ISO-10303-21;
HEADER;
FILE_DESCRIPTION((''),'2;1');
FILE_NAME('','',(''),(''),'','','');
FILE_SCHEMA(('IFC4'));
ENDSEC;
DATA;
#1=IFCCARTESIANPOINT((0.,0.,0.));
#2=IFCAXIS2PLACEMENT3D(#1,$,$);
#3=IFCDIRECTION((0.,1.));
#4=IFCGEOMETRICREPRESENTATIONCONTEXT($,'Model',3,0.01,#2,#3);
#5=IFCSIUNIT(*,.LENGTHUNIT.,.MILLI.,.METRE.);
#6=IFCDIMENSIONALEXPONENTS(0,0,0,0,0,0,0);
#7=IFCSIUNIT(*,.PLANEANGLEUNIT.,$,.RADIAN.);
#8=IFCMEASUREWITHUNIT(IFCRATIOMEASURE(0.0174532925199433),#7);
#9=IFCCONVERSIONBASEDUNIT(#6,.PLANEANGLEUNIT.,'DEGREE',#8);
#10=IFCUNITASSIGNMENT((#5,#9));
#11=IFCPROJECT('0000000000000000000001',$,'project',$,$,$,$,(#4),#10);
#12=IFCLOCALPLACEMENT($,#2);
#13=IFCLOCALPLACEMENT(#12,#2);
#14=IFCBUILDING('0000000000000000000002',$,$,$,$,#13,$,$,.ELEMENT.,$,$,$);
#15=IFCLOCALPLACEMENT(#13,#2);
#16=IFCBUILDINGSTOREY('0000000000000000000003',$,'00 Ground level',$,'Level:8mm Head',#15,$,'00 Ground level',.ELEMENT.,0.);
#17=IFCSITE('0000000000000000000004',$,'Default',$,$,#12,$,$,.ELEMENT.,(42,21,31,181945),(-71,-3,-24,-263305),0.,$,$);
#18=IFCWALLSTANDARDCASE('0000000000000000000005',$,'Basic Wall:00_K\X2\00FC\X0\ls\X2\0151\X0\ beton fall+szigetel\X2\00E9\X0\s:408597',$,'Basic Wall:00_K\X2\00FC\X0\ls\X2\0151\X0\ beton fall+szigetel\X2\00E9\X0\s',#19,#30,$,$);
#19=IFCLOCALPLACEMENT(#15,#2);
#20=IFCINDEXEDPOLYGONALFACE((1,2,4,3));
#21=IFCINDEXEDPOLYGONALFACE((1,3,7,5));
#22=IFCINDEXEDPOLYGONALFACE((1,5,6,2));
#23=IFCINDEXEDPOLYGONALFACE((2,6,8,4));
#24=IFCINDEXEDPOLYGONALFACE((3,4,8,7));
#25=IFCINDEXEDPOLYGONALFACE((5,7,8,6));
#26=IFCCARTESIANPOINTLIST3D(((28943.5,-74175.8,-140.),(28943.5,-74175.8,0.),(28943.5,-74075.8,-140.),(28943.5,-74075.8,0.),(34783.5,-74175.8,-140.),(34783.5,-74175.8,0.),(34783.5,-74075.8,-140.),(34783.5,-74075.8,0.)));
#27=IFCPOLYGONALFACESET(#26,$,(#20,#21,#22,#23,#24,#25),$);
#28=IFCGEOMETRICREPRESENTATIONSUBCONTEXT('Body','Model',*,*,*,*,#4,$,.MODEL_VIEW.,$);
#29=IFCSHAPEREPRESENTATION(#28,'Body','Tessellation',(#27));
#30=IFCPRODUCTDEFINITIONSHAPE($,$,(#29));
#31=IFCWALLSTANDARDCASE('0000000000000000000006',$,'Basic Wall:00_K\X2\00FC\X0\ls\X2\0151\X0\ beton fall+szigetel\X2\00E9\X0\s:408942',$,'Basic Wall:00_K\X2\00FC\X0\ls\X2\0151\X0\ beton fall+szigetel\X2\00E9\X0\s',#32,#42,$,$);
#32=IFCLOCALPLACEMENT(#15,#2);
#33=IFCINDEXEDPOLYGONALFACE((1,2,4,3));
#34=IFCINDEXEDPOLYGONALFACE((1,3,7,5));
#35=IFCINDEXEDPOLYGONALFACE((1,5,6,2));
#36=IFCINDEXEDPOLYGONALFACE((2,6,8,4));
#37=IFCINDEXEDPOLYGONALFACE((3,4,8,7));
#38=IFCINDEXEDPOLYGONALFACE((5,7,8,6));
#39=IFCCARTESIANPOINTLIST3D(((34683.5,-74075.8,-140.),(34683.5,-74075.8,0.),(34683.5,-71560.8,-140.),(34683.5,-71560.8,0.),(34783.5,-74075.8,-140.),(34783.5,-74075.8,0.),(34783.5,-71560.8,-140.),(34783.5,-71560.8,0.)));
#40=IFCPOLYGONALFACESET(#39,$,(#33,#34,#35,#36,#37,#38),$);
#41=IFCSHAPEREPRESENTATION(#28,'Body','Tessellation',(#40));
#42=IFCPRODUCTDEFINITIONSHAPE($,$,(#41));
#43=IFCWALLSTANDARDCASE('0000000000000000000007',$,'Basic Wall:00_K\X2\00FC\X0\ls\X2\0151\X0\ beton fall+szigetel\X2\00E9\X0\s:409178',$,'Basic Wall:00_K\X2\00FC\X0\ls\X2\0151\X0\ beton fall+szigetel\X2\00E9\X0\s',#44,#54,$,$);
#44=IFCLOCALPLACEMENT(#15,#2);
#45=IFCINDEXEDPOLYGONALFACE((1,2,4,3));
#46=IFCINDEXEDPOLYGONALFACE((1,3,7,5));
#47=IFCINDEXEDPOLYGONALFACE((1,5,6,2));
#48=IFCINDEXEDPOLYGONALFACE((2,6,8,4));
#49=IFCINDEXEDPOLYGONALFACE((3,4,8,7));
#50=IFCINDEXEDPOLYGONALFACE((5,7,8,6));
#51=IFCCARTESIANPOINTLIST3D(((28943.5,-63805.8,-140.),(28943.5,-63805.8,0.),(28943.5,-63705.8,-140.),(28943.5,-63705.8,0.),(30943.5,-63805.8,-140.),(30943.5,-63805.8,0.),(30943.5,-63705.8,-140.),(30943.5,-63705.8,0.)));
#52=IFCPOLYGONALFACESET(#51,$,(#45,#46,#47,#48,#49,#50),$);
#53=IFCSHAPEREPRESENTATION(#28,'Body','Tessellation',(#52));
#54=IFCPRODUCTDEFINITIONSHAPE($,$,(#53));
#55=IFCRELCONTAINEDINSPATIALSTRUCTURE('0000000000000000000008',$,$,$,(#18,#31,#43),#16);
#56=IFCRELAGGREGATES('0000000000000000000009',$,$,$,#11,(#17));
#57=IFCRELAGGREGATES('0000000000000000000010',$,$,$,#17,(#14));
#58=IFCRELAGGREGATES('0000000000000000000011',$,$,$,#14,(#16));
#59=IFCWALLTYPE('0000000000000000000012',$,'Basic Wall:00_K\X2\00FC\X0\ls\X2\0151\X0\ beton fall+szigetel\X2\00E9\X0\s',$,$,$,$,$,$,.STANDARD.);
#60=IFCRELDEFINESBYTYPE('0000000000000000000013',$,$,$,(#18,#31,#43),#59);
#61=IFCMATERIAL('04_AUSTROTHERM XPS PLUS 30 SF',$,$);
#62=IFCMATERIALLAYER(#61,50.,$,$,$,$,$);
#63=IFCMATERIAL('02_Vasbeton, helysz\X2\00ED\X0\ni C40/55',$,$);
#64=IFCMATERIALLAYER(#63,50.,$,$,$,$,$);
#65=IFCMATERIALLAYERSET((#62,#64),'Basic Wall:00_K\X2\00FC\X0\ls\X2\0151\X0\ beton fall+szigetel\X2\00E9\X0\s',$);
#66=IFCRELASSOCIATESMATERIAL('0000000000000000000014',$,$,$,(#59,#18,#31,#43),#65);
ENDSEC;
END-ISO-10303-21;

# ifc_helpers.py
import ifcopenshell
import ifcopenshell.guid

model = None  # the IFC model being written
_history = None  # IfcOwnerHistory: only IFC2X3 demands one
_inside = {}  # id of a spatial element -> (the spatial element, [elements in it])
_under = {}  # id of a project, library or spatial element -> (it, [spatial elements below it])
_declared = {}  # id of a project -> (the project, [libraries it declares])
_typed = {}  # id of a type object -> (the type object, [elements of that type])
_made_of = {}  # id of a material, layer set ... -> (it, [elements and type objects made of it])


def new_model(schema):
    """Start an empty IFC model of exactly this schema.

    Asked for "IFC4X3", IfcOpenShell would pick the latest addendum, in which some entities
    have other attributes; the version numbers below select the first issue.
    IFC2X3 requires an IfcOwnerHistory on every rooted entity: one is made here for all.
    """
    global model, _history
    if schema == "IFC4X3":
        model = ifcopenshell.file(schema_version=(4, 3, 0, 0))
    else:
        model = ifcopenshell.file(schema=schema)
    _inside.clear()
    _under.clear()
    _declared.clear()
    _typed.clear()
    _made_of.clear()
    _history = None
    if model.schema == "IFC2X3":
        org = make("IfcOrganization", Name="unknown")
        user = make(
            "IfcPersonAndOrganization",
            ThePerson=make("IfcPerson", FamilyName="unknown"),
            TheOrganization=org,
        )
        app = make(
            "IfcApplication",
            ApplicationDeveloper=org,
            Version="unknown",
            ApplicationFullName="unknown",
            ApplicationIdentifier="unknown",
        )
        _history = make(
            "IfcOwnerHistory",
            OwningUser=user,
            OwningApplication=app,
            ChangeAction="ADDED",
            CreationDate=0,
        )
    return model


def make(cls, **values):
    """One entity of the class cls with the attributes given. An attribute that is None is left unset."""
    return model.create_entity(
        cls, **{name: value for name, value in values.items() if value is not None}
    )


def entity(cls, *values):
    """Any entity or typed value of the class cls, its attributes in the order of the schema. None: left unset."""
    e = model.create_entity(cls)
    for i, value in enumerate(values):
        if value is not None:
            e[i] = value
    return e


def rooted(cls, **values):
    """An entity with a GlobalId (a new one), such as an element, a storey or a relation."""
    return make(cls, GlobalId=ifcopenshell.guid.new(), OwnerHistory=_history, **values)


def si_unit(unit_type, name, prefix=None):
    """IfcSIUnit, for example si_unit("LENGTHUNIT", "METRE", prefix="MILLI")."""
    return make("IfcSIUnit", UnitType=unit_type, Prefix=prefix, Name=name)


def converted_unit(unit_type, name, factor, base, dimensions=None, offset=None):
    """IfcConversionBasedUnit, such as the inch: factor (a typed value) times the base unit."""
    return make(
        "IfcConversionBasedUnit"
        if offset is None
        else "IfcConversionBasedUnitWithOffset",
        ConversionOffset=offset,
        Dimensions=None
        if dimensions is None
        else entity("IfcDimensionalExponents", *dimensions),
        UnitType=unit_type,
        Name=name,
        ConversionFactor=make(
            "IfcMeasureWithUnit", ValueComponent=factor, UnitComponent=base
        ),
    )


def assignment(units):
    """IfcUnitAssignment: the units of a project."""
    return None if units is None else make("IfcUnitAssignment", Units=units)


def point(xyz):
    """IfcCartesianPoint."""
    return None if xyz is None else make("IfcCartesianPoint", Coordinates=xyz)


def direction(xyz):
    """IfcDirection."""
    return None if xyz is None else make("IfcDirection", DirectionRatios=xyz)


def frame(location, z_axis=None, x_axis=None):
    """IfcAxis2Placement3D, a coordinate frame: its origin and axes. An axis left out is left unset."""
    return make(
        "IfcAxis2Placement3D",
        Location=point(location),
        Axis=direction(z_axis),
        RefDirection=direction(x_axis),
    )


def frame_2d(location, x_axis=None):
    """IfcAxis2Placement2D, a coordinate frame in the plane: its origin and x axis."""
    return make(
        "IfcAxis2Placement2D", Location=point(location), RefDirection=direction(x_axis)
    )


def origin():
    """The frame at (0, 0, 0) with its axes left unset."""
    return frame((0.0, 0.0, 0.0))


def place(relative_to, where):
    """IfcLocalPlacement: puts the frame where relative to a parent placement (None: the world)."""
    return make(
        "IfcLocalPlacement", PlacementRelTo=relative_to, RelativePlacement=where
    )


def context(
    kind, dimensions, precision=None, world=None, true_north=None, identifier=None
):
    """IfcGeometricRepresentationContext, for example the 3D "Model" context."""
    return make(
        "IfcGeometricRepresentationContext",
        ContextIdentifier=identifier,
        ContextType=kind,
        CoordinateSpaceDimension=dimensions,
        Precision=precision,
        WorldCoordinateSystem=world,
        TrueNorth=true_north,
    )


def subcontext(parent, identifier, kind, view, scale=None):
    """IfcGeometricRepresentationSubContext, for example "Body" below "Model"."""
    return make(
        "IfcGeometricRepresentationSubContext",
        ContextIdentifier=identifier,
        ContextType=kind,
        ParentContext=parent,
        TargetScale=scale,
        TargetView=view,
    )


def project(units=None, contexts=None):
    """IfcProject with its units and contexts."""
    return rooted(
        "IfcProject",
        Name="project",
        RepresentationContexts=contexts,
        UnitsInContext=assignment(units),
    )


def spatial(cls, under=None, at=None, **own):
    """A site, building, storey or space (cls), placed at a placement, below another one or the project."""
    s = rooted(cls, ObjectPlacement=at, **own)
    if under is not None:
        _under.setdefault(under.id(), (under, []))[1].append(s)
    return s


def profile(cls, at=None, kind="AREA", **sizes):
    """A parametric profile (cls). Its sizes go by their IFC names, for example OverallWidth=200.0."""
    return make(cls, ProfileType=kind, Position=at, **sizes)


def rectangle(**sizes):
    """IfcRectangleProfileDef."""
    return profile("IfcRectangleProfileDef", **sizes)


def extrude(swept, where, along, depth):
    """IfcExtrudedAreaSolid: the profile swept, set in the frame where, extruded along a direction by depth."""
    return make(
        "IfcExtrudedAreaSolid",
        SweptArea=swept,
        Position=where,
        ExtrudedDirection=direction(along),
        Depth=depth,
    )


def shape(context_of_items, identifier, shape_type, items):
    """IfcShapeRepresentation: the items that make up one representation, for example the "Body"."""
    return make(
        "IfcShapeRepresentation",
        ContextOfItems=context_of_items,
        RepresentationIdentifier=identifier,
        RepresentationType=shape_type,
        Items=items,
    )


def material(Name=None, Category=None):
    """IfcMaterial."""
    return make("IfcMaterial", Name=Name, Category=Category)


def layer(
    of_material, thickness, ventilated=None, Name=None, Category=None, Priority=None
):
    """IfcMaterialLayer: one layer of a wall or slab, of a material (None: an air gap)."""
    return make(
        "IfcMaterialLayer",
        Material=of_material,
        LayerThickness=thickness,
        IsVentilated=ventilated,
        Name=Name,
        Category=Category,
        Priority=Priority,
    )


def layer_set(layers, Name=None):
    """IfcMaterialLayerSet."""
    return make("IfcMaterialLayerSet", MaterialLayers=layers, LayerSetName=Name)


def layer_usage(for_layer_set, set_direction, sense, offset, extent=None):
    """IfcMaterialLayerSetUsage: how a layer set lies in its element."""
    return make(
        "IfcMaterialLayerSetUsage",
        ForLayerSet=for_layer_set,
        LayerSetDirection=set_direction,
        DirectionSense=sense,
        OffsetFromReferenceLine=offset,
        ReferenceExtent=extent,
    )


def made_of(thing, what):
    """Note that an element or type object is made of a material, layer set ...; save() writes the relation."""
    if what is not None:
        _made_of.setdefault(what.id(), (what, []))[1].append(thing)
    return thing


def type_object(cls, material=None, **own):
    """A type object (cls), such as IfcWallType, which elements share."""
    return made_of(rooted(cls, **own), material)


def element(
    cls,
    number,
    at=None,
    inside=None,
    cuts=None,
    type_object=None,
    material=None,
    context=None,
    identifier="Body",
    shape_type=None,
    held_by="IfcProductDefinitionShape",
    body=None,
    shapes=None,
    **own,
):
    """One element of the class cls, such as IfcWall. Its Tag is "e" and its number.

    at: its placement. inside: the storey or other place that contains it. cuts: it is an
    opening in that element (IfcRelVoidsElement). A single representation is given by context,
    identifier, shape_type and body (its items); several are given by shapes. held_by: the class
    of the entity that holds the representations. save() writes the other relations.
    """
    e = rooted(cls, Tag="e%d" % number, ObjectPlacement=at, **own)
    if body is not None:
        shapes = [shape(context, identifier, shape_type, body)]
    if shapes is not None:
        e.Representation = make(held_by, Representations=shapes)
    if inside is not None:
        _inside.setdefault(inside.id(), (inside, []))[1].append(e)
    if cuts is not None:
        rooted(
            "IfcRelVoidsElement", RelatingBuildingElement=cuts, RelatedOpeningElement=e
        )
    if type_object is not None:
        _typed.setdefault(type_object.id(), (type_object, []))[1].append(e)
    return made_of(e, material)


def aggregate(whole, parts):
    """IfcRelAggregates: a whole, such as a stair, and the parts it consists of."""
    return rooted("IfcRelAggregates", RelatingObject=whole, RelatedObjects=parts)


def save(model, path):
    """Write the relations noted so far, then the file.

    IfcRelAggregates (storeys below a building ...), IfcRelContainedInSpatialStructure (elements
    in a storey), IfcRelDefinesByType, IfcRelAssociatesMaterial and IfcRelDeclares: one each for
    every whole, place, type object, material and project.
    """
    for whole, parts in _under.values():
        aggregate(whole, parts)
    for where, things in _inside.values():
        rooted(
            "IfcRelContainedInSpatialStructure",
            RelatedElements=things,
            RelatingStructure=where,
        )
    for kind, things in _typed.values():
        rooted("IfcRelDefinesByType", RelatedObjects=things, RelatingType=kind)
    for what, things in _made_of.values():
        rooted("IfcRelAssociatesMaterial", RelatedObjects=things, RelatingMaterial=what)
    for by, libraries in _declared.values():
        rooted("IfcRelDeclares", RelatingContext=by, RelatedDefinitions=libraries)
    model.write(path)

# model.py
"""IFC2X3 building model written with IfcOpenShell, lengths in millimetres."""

from ifc_helpers import new_model, entity, si_unit, converted_unit, direction, frame, frame_2d, origin, place, context, subcontext, project, spatial, rectangle, extrude, material, layer, layer_set, layer_usage, type_object, element, save


model = new_model("IFC2X3")

# Units and contexts
model_context = context("Model", 3, precision=0.01, world=origin(), true_north=direction((0.0, 1.0)))
body_context = subcontext(model_context, "Body", "Model", "MODEL_VIEW")
ifc_project = project(units=[si_unit("LENGTHUNIT", "METRE", prefix="MILLI"), converted_unit("PLANEANGLEUNIT", "DEGREE", entity("IfcRatioMeasure", 0.0174532925199433), si_unit("PLANEANGLEUNIT", "RADIAN"), dimensions=[0, 0, 0, 0, 0, 0, 0])], contexts=[model_context])

# Site, building, storey
site_placement = place(None, origin())
site = spatial("IfcSite", under=ifc_project, at=site_placement, Name="Default", CompositionType="ELEMENT", RefLatitude=(42, 21, 31, 181945), RefLongitude=(-71, -3, -24, -263305), RefElevation=0.0)
building_placement = place(site_placement, origin())
building = spatial("IfcBuilding", under=site, at=building_placement, CompositionType="ELEMENT")
storey_placement = place(building_placement, origin())
storey = spatial("IfcBuildingStorey", under=building, at=storey_placement, Name="00 Ground level", ObjectType="Level:8mm Head", LongName="00 Ground level", CompositionType="ELEMENT", Elevation=0.0)

# Walls
ifc_material_1 = material(Name="04_AUSTROTHERM XPS PLUS 30 SF")
ifc_layer_1 = layer(ifc_material_1, 50.0)
ifc_material_2 = material(Name="02_Vasbeton, helyszíni C40/55")
ifc_layer_2 = layer(ifc_material_2, 50.0)
ifc_layer_set = layer_set([ifc_layer_1, ifc_layer_2], Name="Basic Wall:00_Külső beton fall+szigetelés")
ifc_layer_usage_1 = layer_usage(ifc_layer_set, "AXIS2", "NEGATIVE", 50.0)
wall_type = type_object("IfcWallType", Name="Basic Wall:00_Külső beton fall+szigetelés", PredefinedType="STANDARD", material=ifc_layer_set)
wall_1_placement = place(storey_placement, frame((34783.5, -74125.8, -140.0), z_axis=(0.0, 0.0, 1.0), x_axis=(-1.0, 0.0, 0.0)))
element("IfcWallStandardCase", 1, at=wall_1_placement, inside=storey, type_object=wall_type, material=ifc_layer_usage_1, Name="Basic Wall:00_Külső beton fall+szigetelés:408597", ObjectType="Basic Wall:00_Külső beton fall+szigetelés", context=body_context, shape_type="SweptSolid", body=[
    extrude(rectangle(XDim=5840.0, YDim=100.0, at=frame_2d((2920.0, 0.0), x_axis=(-1.0, 0.0))), origin(), (0.0, 0.0, 1.0), 140.0),
])
ifc_layer_usage_2 = layer_usage(ifc_layer_set, "AXIS2", "NEGATIVE", 50.0)
wall_2_placement = place(storey_placement, frame((34733.5, -71560.8, -140.0), z_axis=(0.0, 0.0, 1.0), x_axis=(0.0, -1.0, 0.0)))
element("IfcWallStandardCase", 2, at=wall_2_placement, inside=storey, type_object=wall_type, material=ifc_layer_usage_2, Name="Basic Wall:00_Külső beton fall+szigetelés:408942", ObjectType="Basic Wall:00_Külső beton fall+szigetelés", context=body_context, shape_type="SweptSolid", body=[
    extrude(rectangle(XDim=2515.0, YDim=100.0, at=frame_2d((1257.5, 0.0), x_axis=(-1.0, 0.0))), origin(), (0.0, 0.0, 1.0), 140.0),
])
ifc_layer_usage_3 = layer_usage(ifc_layer_set, "AXIS2", "NEGATIVE", 50.0)
wall_3_placement = place(storey_placement, frame((28943.5, -63755.8, -140.0)))
element("IfcWallStandardCase", 3, at=wall_3_placement, inside=storey, type_object=wall_type, material=ifc_layer_usage_3, Name="Basic Wall:00_Külső beton fall+szigetelés:409178", ObjectType="Basic Wall:00_Külső beton fall+szigetelés", context=body_context, shape_type="SweptSolid", body=[
    extrude(rectangle(XDim=2000.0, YDim=100.0, at=frame_2d((1000.0, 0.0), x_axis=(-1.0, 0.0))), origin(), (0.0, 0.0, 1.0), 140.0),
])

save(model, "model.ifc")
